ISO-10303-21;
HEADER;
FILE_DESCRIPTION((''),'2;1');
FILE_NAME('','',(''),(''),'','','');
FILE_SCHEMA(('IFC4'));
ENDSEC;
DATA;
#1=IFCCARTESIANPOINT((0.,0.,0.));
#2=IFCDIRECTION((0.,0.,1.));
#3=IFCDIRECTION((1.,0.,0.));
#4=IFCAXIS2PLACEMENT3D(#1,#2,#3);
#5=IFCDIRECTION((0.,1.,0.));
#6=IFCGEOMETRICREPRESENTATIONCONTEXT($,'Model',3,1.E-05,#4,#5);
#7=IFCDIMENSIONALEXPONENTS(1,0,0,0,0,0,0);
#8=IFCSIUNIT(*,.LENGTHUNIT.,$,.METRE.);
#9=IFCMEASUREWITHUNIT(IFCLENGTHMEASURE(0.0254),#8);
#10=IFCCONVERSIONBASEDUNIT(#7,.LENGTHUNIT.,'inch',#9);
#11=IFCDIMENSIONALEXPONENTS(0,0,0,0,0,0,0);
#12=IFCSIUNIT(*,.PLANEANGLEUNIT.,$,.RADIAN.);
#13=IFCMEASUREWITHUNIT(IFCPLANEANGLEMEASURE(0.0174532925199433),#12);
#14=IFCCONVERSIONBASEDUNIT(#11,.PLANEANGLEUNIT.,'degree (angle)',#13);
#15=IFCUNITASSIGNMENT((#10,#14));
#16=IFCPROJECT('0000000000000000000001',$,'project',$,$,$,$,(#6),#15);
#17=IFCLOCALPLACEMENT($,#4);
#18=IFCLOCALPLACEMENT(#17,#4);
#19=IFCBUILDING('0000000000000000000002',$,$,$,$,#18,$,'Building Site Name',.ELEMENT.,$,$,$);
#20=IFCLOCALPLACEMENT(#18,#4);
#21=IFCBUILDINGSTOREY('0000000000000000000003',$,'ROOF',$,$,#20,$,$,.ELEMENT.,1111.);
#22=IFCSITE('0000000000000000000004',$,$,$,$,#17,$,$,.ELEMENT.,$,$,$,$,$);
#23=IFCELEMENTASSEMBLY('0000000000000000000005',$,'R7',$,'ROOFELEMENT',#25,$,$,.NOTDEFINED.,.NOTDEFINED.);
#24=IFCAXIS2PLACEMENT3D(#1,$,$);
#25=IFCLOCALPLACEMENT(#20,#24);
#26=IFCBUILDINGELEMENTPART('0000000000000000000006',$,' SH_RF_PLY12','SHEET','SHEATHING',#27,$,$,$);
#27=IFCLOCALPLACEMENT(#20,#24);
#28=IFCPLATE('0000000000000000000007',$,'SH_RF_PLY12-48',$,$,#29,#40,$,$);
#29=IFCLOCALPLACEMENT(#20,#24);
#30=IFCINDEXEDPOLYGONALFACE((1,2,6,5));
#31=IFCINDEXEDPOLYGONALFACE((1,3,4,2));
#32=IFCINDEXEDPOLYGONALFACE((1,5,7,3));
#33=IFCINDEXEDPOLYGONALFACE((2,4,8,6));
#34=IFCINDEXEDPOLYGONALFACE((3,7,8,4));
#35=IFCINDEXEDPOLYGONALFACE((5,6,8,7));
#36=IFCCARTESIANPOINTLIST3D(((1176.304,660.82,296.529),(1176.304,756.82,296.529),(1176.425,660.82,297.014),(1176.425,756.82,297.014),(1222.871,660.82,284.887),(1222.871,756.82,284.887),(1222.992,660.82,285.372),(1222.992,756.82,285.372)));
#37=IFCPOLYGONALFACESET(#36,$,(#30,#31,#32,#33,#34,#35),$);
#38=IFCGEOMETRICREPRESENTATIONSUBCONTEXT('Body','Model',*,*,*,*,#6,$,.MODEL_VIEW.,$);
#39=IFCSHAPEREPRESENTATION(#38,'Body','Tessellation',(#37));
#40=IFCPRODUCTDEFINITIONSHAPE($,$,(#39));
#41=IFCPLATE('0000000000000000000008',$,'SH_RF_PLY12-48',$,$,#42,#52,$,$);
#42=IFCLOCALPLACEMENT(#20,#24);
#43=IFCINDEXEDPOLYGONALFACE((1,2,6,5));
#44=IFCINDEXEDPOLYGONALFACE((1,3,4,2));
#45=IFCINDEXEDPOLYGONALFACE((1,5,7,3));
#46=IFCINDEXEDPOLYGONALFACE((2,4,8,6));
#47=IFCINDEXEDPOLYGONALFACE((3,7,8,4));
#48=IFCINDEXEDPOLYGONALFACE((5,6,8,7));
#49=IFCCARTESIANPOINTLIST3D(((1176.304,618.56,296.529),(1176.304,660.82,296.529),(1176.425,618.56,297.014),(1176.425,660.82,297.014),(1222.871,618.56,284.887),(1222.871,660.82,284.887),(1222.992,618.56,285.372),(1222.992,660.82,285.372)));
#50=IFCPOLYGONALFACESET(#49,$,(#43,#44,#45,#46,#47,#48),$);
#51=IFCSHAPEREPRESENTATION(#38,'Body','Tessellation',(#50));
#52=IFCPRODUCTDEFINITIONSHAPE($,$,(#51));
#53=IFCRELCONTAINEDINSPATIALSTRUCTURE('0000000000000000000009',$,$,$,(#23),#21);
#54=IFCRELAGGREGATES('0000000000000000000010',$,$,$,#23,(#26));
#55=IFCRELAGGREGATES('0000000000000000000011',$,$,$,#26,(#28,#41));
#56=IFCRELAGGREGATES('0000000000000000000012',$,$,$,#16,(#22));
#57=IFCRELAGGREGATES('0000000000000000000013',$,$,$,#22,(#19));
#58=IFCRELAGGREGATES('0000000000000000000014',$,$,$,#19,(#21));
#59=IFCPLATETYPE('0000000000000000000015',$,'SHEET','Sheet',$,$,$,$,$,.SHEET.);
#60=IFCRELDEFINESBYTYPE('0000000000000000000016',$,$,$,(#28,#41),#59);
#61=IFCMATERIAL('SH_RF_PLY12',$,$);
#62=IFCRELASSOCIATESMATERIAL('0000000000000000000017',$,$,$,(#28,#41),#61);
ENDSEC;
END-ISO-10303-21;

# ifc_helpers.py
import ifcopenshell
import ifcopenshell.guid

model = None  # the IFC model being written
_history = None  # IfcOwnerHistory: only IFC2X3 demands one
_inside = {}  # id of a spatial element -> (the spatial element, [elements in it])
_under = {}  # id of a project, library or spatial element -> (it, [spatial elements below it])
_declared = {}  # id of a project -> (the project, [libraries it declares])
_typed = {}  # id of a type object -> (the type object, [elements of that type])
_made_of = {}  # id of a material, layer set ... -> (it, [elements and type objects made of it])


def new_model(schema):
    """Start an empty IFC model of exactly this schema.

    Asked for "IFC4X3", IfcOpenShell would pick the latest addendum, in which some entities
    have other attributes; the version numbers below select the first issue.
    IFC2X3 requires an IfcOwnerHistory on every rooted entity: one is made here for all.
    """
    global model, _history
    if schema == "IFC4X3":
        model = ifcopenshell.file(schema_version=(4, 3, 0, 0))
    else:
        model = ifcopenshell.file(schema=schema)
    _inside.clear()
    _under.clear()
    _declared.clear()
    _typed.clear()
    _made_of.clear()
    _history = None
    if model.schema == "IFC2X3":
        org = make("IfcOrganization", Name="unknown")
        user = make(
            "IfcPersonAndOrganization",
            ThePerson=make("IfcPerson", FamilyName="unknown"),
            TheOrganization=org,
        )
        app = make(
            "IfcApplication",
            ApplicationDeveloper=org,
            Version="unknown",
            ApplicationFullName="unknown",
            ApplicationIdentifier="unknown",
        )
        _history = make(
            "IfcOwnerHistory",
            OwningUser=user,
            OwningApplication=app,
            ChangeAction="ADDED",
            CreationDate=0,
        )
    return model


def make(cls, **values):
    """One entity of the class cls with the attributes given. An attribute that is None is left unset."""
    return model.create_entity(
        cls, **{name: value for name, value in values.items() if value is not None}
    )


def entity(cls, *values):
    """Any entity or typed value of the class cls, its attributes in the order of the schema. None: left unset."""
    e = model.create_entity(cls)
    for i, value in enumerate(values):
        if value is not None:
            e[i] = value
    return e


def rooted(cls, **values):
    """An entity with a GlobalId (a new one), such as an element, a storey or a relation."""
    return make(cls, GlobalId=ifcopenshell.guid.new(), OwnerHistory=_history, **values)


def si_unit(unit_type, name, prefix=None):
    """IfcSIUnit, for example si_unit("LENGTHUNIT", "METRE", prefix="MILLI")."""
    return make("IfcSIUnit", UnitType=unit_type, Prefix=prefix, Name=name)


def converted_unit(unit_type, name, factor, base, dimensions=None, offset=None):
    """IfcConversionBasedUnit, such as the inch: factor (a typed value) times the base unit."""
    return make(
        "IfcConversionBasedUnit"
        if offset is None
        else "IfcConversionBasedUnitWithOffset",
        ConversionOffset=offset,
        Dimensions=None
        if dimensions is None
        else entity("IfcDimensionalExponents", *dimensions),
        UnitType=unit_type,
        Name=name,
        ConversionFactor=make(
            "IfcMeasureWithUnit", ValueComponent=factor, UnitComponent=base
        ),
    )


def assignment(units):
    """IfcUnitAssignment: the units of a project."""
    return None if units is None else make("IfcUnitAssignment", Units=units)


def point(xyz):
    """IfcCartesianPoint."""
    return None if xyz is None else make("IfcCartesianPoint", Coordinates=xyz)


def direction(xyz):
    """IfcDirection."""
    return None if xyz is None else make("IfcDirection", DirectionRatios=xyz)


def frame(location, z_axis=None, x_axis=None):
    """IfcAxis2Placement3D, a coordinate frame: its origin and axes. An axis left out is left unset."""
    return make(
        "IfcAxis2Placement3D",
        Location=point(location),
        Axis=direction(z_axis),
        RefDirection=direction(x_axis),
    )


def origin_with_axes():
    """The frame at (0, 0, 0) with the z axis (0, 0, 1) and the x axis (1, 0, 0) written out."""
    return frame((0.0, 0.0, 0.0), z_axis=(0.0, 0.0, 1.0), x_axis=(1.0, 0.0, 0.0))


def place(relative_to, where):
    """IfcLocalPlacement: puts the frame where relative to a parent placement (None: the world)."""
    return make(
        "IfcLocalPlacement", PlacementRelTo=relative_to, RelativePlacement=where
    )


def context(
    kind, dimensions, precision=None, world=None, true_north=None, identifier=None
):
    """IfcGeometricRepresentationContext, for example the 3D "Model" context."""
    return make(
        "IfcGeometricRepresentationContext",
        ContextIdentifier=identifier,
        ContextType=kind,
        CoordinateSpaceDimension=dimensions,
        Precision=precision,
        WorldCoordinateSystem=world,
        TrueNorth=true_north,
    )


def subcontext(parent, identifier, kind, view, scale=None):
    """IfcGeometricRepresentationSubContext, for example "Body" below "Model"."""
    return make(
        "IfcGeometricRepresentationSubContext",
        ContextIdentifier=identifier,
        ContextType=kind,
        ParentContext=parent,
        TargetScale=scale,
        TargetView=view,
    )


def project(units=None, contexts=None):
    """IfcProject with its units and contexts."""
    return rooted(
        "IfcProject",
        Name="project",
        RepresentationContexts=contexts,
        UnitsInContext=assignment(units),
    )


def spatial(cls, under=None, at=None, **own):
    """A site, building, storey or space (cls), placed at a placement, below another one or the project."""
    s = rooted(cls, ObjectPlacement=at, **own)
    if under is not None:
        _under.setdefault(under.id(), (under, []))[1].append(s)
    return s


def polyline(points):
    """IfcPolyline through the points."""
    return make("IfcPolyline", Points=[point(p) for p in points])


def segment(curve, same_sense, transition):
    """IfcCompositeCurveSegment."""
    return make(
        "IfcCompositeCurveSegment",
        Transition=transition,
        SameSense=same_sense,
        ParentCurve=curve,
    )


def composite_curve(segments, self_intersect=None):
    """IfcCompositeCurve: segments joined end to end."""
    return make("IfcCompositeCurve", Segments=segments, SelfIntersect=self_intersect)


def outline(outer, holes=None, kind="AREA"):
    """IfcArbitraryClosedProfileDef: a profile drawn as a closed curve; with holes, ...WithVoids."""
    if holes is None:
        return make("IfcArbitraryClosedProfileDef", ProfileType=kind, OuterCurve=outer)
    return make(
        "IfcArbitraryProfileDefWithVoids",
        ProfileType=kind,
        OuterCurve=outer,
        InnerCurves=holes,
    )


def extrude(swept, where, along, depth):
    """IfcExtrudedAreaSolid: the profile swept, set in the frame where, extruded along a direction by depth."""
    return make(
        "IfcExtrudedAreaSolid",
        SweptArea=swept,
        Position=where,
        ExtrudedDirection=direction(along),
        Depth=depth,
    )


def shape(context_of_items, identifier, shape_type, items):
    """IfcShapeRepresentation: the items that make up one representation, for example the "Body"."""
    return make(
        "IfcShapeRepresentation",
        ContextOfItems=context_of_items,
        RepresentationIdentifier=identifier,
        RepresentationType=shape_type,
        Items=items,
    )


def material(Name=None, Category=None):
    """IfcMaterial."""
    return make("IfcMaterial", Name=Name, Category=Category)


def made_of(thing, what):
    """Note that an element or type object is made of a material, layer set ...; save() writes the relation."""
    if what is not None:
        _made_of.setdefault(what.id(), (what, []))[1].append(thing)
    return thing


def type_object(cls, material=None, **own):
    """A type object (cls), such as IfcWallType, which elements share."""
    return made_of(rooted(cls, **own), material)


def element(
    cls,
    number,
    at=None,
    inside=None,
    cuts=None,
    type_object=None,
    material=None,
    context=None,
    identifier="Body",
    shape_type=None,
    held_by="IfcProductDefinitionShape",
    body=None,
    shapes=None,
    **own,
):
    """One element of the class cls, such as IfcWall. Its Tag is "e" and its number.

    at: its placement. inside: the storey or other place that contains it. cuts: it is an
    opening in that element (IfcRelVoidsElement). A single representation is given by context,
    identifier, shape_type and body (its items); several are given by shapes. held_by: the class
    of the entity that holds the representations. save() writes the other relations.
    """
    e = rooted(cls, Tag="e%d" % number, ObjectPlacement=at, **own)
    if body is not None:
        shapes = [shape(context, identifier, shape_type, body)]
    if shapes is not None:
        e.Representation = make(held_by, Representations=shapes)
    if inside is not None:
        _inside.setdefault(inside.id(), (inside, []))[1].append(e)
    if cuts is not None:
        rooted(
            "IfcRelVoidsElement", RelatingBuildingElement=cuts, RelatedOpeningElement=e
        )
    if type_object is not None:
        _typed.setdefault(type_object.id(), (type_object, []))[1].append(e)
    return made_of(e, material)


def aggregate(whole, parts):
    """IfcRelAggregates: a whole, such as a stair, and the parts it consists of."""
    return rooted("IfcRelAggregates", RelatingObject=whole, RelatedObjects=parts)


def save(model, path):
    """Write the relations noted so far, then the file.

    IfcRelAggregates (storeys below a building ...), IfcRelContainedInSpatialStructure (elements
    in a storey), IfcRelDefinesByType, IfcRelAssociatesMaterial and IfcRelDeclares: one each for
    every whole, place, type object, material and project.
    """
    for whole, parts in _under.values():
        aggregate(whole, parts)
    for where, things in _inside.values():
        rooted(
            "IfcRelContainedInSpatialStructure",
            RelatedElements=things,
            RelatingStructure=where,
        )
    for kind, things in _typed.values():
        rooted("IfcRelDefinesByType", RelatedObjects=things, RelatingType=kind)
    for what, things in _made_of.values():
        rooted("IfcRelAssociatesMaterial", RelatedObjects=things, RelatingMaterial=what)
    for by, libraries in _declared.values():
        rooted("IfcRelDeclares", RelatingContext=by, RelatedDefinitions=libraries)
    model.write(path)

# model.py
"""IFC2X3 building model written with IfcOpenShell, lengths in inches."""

from ifc_helpers import new_model, entity, si_unit, converted_unit, direction, frame, origin_with_axes, place, context, subcontext, project, spatial, polyline, segment, composite_curve, outline, extrude, material, type_object, element, aggregate, save


model = new_model("IFC2X3")

# Units and contexts
model_context = context("Model", 3, precision=1e-05, world=origin_with_axes(), true_north=direction((0.0, 1.0, 0.0)))
body_context = subcontext(model_context, "Body", "Model", "MODEL_VIEW")
ifc_project = project(units=[converted_unit("LENGTHUNIT", "inch", entity("IfcLengthMeasure", 0.0254), si_unit("LENGTHUNIT", "METRE"), dimensions=[1, 0, 0, 0, 0, 0, 0]), converted_unit("PLANEANGLEUNIT", "degree (angle)", entity("IfcPlaneAngleMeasure", 0.0174532925199433), si_unit("PLANEANGLEUNIT", "RADIAN"), dimensions=[0, 0, 0, 0, 0, 0, 0])], contexts=[model_context])

# Site, building, storey
site_placement = place(None, origin_with_axes())
site = spatial("IfcSite", under=ifc_project, at=site_placement, CompositionType="ELEMENT")
building_placement = place(site_placement, origin_with_axes())
building = spatial("IfcBuilding", under=site, at=building_placement, LongName="Building Site Name", CompositionType="ELEMENT")
storey_placement = place(building_placement, origin_with_axes())
storey = spatial("IfcBuildingStorey", under=building, at=storey_placement, Name="ROOF", CompositionType="ELEMENT", Elevation=1111.0)

# Element assembly, building element part, plates
assembly_placement = place(storey_placement, origin_with_axes())
assembly = element("IfcElementAssembly", 1, at=assembly_placement, inside=storey, Name="R7", ObjectType="ROOFELEMENT", AssemblyPlace="NOTDEFINED", PredefinedType="NOTDEFINED")
building_element_part_1 = element("IfcBuildingElementPart", 2, Name=" SH_RF_PLY12", Description="SHEET", ObjectType="SHEATHING")
aggregate(assembly, [building_element_part_1])
ifc_material_1 = material(Name="SH_RF_PLY12")
plate_type = type_object("IfcPlateType", Name="SHEET", Description="Sheet", PredefinedType="SHEET")
plate_1_placement = place(assembly_placement, frame((1199.709, 708.82, 291.193), z_axis=(0.242536, 0.0, 0.970143), x_axis=(-0.970143, 0.0, 0.242536)))
plate_1 = element("IfcPlate", 3, at=plate_1_placement, type_object=plate_type, material=ifc_material_1, Name="SH_RF_PLY12-48", context=body_context, shape_type="SweptSolid", body=[
    extrude(outline(composite_curve([segment(polyline([(-24.0, -0.5), (24.0, -0.5), (24.0, 0.0), (-24.0, 0.0), (-24.0, -0.5)]), True, "CONTINUOUS")], self_intersect=False)), frame((0.0, -48.0, 0.0), z_axis=(0.0, 1.0, 0.0), x_axis=(-1.0, 0.0, 0.0)), (0.0, 0.0, 1.0), 96.0),
])
plate_2_placement = place(assembly_placement, frame((1199.709, 612.82, 291.193), z_axis=(0.242536, 0.0, 0.970143), x_axis=(-0.970143, 0.0, 0.242536)))
plate_2 = element("IfcPlate", 4, at=plate_2_placement, type_object=plate_type, material=ifc_material_1, Name="SH_RF_PLY12-48", context=body_context, shape_type="SweptSolid", body=[
    extrude(outline(composite_curve([segment(polyline([(-24.0, -0.5), (24.0, -0.5), (24.0, 0.0), (-24.0, 0.0), (-24.0, -0.5)]), True, "CONTINUOUS")], self_intersect=False)), frame((0.0, -48.0, 0.0), z_axis=(0.0, 1.0, 0.0), x_axis=(-1.0, 0.0, 0.0)), (0.0, 0.0, 1.0), 42.26),
])
aggregate(building_element_part_1, [plate_1, plate_2])

save(model, "model.ifc")
